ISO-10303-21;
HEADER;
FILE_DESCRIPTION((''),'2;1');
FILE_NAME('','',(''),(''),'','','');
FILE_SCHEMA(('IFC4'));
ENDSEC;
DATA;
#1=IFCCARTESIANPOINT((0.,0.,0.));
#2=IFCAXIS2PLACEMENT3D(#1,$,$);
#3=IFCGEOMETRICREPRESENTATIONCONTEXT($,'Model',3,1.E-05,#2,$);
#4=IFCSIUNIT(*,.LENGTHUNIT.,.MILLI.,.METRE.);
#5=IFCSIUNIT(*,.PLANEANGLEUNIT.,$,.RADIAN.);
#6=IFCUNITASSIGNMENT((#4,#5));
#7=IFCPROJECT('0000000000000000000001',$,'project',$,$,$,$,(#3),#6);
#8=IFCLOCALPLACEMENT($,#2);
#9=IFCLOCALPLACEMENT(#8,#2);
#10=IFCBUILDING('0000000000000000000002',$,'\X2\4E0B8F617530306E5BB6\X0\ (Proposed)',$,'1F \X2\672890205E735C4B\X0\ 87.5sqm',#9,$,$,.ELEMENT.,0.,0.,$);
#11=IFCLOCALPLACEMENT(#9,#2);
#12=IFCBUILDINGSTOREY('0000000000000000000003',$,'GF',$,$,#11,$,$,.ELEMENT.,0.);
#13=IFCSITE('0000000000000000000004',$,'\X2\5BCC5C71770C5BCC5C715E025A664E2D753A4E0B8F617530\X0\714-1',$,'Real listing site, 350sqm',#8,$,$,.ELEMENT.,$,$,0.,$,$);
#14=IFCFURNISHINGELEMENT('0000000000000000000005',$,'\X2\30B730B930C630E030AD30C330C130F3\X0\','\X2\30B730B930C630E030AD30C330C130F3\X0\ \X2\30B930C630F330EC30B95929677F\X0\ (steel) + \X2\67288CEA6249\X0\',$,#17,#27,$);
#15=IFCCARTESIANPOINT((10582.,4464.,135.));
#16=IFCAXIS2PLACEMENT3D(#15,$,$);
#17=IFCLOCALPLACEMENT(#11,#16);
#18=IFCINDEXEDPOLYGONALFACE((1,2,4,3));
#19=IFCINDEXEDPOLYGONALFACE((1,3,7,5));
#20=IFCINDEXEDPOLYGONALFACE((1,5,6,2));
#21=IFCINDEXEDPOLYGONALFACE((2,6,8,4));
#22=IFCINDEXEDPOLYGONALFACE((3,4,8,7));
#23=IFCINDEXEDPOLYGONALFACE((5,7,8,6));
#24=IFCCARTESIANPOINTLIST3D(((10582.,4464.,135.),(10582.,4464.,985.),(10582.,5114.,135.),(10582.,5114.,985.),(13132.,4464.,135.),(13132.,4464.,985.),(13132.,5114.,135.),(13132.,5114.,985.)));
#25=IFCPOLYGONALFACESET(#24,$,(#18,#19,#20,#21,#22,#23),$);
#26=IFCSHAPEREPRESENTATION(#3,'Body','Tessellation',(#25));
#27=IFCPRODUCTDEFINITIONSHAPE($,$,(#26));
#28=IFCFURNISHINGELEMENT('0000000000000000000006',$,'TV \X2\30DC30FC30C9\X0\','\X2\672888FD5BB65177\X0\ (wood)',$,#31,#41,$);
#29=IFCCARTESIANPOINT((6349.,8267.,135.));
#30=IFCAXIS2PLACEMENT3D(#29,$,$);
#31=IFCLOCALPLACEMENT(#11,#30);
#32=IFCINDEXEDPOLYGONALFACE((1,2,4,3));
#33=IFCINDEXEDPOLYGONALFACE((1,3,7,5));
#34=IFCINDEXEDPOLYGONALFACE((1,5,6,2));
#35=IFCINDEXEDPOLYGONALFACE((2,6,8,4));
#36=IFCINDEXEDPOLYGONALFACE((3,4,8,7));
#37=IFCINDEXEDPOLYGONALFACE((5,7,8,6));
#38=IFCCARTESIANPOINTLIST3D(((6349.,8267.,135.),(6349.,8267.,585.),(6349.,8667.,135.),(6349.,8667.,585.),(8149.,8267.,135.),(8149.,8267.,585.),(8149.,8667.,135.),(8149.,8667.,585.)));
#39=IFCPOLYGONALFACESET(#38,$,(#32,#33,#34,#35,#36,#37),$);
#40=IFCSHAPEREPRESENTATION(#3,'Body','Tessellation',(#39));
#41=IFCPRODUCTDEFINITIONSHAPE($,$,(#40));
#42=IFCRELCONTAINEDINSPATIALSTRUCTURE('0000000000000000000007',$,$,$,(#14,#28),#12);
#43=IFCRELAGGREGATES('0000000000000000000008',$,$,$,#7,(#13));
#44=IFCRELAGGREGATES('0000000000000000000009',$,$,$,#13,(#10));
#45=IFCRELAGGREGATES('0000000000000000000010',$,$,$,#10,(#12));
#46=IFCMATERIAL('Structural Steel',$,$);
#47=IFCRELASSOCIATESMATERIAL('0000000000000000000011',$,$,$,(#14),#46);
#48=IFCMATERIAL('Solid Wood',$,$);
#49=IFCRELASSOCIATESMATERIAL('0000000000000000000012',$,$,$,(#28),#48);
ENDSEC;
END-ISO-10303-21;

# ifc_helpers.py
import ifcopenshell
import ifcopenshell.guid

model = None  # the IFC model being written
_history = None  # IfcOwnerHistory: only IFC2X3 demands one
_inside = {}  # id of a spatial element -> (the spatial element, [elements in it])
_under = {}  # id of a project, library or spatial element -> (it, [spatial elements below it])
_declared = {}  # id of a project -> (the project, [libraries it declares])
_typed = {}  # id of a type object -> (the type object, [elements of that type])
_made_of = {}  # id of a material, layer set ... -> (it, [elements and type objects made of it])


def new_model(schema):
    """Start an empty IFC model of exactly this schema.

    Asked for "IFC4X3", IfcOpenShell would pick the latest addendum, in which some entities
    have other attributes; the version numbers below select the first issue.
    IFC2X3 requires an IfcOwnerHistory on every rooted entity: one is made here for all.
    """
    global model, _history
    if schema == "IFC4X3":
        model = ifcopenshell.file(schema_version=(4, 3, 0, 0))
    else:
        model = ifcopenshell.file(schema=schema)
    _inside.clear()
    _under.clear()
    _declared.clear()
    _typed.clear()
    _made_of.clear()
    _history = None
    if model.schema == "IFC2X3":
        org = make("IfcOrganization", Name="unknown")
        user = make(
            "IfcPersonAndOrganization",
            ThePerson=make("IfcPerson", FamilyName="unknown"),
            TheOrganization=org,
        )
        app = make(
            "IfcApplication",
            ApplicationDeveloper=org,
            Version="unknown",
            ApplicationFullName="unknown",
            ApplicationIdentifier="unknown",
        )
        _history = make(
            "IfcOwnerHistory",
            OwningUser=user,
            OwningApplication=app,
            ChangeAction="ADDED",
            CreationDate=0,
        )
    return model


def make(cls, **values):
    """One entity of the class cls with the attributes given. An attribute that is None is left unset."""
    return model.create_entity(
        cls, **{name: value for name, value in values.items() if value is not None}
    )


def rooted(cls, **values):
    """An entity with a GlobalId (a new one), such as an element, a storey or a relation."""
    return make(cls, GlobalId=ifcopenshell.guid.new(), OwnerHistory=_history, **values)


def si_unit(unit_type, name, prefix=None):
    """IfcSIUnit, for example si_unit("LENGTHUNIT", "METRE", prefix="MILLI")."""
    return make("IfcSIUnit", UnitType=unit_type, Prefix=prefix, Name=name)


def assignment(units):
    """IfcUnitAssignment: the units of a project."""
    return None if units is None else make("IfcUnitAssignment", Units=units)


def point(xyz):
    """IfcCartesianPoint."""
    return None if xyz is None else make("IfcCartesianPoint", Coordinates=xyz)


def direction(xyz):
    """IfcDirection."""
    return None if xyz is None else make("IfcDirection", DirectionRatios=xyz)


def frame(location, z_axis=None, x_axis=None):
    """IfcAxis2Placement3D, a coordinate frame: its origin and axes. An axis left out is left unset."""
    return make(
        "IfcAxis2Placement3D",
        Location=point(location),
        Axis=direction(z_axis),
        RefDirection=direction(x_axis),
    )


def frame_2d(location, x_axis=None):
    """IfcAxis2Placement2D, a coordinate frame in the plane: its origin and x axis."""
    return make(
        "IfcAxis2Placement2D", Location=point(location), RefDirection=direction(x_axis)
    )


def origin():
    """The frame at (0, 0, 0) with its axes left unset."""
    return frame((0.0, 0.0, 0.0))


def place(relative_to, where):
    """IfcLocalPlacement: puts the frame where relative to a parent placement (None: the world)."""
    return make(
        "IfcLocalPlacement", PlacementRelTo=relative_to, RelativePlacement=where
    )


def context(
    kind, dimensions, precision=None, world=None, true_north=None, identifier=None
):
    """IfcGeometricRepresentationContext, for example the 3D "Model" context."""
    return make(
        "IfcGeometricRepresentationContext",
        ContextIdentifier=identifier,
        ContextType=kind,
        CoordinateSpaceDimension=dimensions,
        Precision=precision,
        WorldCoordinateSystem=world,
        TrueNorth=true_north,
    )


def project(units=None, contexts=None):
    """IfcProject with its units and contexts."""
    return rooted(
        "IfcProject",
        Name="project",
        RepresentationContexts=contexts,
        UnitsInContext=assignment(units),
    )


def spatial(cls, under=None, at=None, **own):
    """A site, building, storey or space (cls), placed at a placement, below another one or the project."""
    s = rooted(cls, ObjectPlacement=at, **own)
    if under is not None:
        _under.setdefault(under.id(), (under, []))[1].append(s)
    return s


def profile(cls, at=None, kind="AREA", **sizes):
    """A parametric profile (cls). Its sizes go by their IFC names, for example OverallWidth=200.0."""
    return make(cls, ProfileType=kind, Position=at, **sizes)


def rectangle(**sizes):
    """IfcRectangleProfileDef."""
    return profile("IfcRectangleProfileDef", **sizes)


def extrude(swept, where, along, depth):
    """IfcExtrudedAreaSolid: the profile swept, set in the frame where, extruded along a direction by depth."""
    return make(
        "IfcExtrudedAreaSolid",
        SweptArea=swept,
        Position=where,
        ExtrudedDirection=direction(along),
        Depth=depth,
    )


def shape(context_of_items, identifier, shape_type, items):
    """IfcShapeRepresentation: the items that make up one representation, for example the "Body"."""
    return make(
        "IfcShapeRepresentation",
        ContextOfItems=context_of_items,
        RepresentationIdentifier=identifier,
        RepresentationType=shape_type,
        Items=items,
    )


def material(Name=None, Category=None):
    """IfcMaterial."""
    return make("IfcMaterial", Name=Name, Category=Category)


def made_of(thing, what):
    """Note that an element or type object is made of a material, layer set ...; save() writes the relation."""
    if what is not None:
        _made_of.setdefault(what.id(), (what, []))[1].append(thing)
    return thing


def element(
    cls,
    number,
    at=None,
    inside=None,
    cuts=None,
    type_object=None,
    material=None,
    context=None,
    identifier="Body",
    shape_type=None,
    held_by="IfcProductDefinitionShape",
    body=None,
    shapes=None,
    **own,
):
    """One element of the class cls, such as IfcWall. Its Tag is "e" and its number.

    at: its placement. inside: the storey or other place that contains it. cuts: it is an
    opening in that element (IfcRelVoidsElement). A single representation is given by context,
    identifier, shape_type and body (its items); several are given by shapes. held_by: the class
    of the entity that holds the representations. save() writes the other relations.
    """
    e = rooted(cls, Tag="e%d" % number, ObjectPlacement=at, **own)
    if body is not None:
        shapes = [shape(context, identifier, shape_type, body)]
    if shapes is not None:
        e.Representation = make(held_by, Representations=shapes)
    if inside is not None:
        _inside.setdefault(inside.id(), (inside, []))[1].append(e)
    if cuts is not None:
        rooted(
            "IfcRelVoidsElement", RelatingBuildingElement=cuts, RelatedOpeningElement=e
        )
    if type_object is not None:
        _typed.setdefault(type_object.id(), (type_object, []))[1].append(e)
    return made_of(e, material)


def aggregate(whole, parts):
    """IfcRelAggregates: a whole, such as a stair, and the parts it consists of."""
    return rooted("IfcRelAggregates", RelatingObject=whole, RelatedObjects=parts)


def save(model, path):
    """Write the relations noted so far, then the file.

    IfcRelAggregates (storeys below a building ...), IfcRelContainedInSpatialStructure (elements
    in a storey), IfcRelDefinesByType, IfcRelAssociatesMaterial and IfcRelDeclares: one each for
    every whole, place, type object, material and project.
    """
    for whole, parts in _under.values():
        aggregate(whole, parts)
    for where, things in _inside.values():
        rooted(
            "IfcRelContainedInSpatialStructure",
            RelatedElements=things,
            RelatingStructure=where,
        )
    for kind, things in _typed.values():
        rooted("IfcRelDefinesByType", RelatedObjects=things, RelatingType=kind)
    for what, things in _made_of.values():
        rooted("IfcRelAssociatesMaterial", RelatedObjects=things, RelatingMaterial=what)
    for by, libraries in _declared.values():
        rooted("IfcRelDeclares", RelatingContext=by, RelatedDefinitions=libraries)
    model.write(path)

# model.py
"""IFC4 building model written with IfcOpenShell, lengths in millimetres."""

from ifc_helpers import new_model, si_unit, frame, frame_2d, origin, place, context, project, spatial, rectangle, extrude, material, element, save


model = new_model("IFC4")

# Units and contexts
model_context = context("Model", 3, precision=1e-05, world=origin())
ifc_project = project(units=[si_unit("LENGTHUNIT", "METRE", prefix="MILLI"), si_unit("PLANEANGLEUNIT", "RADIAN")], contexts=[model_context])

# Site, building, storey
site_placement = place(None, origin())
site = spatial("IfcSite", under=ifc_project, at=site_placement, Name="富山県富山市婦中町下轡田714-1", ObjectType="Real listing site, 350sqm", CompositionType="ELEMENT", RefElevation=0.0)
building_placement = place(site_placement, origin())
building = spatial("IfcBuilding", under=site, at=building_placement, Name="下轡田の家 (Proposed)", ObjectType="1F 木造平屋 87.5sqm", CompositionType="ELEMENT", ElevationOfRefHeight=0.0, ElevationOfTerrain=0.0)
storey_placement = place(building_placement, origin())
storey = spatial("IfcBuildingStorey", under=building, at=storey_placement, Name="GF", CompositionType="ELEMENT", Elevation=0.0)

# Shared definitions
ifc_material_1 = material(Name="Solid Wood")

# Furnishing elements
ifc_material_2 = material(Name="Structural Steel")
furnishing_1_placement = place(storey_placement, frame((10582.0, 4464.0, 135.0)))
element("IfcFurnishingElement", 1, at=furnishing_1_placement, inside=storey, material=ifc_material_2, Name="システムキッチン", Description="システムキッチン ステンレス天板 (steel) + 木質扉", context=model_context, shape_type="SweptSolid", body=[
    extrude(rectangle(XDim=2550.0, YDim=650.0, at=frame_2d((1275.0, 325.0))), frame((10582.0, 4464.0, 135.0)), (0.0, 0.0, 1.0), 850.0),
])
furnishing_2_placement = place(storey_placement, frame((6349.0, 8267.0, 135.0)))
element("IfcFurnishingElement", 2, at=furnishing_2_placement, inside=storey, material=ifc_material_1, Name="TV ボード", Description="木製家具 (wood)", context=model_context, shape_type="SweptSolid", body=[
    extrude(rectangle(XDim=1800.0, YDim=400.0, at=frame_2d((900.0, 200.0))), frame((6349.0, 8267.0, 135.0)), (0.0, 0.0, 1.0), 450.0),
])

save(model, "model.ifc")
